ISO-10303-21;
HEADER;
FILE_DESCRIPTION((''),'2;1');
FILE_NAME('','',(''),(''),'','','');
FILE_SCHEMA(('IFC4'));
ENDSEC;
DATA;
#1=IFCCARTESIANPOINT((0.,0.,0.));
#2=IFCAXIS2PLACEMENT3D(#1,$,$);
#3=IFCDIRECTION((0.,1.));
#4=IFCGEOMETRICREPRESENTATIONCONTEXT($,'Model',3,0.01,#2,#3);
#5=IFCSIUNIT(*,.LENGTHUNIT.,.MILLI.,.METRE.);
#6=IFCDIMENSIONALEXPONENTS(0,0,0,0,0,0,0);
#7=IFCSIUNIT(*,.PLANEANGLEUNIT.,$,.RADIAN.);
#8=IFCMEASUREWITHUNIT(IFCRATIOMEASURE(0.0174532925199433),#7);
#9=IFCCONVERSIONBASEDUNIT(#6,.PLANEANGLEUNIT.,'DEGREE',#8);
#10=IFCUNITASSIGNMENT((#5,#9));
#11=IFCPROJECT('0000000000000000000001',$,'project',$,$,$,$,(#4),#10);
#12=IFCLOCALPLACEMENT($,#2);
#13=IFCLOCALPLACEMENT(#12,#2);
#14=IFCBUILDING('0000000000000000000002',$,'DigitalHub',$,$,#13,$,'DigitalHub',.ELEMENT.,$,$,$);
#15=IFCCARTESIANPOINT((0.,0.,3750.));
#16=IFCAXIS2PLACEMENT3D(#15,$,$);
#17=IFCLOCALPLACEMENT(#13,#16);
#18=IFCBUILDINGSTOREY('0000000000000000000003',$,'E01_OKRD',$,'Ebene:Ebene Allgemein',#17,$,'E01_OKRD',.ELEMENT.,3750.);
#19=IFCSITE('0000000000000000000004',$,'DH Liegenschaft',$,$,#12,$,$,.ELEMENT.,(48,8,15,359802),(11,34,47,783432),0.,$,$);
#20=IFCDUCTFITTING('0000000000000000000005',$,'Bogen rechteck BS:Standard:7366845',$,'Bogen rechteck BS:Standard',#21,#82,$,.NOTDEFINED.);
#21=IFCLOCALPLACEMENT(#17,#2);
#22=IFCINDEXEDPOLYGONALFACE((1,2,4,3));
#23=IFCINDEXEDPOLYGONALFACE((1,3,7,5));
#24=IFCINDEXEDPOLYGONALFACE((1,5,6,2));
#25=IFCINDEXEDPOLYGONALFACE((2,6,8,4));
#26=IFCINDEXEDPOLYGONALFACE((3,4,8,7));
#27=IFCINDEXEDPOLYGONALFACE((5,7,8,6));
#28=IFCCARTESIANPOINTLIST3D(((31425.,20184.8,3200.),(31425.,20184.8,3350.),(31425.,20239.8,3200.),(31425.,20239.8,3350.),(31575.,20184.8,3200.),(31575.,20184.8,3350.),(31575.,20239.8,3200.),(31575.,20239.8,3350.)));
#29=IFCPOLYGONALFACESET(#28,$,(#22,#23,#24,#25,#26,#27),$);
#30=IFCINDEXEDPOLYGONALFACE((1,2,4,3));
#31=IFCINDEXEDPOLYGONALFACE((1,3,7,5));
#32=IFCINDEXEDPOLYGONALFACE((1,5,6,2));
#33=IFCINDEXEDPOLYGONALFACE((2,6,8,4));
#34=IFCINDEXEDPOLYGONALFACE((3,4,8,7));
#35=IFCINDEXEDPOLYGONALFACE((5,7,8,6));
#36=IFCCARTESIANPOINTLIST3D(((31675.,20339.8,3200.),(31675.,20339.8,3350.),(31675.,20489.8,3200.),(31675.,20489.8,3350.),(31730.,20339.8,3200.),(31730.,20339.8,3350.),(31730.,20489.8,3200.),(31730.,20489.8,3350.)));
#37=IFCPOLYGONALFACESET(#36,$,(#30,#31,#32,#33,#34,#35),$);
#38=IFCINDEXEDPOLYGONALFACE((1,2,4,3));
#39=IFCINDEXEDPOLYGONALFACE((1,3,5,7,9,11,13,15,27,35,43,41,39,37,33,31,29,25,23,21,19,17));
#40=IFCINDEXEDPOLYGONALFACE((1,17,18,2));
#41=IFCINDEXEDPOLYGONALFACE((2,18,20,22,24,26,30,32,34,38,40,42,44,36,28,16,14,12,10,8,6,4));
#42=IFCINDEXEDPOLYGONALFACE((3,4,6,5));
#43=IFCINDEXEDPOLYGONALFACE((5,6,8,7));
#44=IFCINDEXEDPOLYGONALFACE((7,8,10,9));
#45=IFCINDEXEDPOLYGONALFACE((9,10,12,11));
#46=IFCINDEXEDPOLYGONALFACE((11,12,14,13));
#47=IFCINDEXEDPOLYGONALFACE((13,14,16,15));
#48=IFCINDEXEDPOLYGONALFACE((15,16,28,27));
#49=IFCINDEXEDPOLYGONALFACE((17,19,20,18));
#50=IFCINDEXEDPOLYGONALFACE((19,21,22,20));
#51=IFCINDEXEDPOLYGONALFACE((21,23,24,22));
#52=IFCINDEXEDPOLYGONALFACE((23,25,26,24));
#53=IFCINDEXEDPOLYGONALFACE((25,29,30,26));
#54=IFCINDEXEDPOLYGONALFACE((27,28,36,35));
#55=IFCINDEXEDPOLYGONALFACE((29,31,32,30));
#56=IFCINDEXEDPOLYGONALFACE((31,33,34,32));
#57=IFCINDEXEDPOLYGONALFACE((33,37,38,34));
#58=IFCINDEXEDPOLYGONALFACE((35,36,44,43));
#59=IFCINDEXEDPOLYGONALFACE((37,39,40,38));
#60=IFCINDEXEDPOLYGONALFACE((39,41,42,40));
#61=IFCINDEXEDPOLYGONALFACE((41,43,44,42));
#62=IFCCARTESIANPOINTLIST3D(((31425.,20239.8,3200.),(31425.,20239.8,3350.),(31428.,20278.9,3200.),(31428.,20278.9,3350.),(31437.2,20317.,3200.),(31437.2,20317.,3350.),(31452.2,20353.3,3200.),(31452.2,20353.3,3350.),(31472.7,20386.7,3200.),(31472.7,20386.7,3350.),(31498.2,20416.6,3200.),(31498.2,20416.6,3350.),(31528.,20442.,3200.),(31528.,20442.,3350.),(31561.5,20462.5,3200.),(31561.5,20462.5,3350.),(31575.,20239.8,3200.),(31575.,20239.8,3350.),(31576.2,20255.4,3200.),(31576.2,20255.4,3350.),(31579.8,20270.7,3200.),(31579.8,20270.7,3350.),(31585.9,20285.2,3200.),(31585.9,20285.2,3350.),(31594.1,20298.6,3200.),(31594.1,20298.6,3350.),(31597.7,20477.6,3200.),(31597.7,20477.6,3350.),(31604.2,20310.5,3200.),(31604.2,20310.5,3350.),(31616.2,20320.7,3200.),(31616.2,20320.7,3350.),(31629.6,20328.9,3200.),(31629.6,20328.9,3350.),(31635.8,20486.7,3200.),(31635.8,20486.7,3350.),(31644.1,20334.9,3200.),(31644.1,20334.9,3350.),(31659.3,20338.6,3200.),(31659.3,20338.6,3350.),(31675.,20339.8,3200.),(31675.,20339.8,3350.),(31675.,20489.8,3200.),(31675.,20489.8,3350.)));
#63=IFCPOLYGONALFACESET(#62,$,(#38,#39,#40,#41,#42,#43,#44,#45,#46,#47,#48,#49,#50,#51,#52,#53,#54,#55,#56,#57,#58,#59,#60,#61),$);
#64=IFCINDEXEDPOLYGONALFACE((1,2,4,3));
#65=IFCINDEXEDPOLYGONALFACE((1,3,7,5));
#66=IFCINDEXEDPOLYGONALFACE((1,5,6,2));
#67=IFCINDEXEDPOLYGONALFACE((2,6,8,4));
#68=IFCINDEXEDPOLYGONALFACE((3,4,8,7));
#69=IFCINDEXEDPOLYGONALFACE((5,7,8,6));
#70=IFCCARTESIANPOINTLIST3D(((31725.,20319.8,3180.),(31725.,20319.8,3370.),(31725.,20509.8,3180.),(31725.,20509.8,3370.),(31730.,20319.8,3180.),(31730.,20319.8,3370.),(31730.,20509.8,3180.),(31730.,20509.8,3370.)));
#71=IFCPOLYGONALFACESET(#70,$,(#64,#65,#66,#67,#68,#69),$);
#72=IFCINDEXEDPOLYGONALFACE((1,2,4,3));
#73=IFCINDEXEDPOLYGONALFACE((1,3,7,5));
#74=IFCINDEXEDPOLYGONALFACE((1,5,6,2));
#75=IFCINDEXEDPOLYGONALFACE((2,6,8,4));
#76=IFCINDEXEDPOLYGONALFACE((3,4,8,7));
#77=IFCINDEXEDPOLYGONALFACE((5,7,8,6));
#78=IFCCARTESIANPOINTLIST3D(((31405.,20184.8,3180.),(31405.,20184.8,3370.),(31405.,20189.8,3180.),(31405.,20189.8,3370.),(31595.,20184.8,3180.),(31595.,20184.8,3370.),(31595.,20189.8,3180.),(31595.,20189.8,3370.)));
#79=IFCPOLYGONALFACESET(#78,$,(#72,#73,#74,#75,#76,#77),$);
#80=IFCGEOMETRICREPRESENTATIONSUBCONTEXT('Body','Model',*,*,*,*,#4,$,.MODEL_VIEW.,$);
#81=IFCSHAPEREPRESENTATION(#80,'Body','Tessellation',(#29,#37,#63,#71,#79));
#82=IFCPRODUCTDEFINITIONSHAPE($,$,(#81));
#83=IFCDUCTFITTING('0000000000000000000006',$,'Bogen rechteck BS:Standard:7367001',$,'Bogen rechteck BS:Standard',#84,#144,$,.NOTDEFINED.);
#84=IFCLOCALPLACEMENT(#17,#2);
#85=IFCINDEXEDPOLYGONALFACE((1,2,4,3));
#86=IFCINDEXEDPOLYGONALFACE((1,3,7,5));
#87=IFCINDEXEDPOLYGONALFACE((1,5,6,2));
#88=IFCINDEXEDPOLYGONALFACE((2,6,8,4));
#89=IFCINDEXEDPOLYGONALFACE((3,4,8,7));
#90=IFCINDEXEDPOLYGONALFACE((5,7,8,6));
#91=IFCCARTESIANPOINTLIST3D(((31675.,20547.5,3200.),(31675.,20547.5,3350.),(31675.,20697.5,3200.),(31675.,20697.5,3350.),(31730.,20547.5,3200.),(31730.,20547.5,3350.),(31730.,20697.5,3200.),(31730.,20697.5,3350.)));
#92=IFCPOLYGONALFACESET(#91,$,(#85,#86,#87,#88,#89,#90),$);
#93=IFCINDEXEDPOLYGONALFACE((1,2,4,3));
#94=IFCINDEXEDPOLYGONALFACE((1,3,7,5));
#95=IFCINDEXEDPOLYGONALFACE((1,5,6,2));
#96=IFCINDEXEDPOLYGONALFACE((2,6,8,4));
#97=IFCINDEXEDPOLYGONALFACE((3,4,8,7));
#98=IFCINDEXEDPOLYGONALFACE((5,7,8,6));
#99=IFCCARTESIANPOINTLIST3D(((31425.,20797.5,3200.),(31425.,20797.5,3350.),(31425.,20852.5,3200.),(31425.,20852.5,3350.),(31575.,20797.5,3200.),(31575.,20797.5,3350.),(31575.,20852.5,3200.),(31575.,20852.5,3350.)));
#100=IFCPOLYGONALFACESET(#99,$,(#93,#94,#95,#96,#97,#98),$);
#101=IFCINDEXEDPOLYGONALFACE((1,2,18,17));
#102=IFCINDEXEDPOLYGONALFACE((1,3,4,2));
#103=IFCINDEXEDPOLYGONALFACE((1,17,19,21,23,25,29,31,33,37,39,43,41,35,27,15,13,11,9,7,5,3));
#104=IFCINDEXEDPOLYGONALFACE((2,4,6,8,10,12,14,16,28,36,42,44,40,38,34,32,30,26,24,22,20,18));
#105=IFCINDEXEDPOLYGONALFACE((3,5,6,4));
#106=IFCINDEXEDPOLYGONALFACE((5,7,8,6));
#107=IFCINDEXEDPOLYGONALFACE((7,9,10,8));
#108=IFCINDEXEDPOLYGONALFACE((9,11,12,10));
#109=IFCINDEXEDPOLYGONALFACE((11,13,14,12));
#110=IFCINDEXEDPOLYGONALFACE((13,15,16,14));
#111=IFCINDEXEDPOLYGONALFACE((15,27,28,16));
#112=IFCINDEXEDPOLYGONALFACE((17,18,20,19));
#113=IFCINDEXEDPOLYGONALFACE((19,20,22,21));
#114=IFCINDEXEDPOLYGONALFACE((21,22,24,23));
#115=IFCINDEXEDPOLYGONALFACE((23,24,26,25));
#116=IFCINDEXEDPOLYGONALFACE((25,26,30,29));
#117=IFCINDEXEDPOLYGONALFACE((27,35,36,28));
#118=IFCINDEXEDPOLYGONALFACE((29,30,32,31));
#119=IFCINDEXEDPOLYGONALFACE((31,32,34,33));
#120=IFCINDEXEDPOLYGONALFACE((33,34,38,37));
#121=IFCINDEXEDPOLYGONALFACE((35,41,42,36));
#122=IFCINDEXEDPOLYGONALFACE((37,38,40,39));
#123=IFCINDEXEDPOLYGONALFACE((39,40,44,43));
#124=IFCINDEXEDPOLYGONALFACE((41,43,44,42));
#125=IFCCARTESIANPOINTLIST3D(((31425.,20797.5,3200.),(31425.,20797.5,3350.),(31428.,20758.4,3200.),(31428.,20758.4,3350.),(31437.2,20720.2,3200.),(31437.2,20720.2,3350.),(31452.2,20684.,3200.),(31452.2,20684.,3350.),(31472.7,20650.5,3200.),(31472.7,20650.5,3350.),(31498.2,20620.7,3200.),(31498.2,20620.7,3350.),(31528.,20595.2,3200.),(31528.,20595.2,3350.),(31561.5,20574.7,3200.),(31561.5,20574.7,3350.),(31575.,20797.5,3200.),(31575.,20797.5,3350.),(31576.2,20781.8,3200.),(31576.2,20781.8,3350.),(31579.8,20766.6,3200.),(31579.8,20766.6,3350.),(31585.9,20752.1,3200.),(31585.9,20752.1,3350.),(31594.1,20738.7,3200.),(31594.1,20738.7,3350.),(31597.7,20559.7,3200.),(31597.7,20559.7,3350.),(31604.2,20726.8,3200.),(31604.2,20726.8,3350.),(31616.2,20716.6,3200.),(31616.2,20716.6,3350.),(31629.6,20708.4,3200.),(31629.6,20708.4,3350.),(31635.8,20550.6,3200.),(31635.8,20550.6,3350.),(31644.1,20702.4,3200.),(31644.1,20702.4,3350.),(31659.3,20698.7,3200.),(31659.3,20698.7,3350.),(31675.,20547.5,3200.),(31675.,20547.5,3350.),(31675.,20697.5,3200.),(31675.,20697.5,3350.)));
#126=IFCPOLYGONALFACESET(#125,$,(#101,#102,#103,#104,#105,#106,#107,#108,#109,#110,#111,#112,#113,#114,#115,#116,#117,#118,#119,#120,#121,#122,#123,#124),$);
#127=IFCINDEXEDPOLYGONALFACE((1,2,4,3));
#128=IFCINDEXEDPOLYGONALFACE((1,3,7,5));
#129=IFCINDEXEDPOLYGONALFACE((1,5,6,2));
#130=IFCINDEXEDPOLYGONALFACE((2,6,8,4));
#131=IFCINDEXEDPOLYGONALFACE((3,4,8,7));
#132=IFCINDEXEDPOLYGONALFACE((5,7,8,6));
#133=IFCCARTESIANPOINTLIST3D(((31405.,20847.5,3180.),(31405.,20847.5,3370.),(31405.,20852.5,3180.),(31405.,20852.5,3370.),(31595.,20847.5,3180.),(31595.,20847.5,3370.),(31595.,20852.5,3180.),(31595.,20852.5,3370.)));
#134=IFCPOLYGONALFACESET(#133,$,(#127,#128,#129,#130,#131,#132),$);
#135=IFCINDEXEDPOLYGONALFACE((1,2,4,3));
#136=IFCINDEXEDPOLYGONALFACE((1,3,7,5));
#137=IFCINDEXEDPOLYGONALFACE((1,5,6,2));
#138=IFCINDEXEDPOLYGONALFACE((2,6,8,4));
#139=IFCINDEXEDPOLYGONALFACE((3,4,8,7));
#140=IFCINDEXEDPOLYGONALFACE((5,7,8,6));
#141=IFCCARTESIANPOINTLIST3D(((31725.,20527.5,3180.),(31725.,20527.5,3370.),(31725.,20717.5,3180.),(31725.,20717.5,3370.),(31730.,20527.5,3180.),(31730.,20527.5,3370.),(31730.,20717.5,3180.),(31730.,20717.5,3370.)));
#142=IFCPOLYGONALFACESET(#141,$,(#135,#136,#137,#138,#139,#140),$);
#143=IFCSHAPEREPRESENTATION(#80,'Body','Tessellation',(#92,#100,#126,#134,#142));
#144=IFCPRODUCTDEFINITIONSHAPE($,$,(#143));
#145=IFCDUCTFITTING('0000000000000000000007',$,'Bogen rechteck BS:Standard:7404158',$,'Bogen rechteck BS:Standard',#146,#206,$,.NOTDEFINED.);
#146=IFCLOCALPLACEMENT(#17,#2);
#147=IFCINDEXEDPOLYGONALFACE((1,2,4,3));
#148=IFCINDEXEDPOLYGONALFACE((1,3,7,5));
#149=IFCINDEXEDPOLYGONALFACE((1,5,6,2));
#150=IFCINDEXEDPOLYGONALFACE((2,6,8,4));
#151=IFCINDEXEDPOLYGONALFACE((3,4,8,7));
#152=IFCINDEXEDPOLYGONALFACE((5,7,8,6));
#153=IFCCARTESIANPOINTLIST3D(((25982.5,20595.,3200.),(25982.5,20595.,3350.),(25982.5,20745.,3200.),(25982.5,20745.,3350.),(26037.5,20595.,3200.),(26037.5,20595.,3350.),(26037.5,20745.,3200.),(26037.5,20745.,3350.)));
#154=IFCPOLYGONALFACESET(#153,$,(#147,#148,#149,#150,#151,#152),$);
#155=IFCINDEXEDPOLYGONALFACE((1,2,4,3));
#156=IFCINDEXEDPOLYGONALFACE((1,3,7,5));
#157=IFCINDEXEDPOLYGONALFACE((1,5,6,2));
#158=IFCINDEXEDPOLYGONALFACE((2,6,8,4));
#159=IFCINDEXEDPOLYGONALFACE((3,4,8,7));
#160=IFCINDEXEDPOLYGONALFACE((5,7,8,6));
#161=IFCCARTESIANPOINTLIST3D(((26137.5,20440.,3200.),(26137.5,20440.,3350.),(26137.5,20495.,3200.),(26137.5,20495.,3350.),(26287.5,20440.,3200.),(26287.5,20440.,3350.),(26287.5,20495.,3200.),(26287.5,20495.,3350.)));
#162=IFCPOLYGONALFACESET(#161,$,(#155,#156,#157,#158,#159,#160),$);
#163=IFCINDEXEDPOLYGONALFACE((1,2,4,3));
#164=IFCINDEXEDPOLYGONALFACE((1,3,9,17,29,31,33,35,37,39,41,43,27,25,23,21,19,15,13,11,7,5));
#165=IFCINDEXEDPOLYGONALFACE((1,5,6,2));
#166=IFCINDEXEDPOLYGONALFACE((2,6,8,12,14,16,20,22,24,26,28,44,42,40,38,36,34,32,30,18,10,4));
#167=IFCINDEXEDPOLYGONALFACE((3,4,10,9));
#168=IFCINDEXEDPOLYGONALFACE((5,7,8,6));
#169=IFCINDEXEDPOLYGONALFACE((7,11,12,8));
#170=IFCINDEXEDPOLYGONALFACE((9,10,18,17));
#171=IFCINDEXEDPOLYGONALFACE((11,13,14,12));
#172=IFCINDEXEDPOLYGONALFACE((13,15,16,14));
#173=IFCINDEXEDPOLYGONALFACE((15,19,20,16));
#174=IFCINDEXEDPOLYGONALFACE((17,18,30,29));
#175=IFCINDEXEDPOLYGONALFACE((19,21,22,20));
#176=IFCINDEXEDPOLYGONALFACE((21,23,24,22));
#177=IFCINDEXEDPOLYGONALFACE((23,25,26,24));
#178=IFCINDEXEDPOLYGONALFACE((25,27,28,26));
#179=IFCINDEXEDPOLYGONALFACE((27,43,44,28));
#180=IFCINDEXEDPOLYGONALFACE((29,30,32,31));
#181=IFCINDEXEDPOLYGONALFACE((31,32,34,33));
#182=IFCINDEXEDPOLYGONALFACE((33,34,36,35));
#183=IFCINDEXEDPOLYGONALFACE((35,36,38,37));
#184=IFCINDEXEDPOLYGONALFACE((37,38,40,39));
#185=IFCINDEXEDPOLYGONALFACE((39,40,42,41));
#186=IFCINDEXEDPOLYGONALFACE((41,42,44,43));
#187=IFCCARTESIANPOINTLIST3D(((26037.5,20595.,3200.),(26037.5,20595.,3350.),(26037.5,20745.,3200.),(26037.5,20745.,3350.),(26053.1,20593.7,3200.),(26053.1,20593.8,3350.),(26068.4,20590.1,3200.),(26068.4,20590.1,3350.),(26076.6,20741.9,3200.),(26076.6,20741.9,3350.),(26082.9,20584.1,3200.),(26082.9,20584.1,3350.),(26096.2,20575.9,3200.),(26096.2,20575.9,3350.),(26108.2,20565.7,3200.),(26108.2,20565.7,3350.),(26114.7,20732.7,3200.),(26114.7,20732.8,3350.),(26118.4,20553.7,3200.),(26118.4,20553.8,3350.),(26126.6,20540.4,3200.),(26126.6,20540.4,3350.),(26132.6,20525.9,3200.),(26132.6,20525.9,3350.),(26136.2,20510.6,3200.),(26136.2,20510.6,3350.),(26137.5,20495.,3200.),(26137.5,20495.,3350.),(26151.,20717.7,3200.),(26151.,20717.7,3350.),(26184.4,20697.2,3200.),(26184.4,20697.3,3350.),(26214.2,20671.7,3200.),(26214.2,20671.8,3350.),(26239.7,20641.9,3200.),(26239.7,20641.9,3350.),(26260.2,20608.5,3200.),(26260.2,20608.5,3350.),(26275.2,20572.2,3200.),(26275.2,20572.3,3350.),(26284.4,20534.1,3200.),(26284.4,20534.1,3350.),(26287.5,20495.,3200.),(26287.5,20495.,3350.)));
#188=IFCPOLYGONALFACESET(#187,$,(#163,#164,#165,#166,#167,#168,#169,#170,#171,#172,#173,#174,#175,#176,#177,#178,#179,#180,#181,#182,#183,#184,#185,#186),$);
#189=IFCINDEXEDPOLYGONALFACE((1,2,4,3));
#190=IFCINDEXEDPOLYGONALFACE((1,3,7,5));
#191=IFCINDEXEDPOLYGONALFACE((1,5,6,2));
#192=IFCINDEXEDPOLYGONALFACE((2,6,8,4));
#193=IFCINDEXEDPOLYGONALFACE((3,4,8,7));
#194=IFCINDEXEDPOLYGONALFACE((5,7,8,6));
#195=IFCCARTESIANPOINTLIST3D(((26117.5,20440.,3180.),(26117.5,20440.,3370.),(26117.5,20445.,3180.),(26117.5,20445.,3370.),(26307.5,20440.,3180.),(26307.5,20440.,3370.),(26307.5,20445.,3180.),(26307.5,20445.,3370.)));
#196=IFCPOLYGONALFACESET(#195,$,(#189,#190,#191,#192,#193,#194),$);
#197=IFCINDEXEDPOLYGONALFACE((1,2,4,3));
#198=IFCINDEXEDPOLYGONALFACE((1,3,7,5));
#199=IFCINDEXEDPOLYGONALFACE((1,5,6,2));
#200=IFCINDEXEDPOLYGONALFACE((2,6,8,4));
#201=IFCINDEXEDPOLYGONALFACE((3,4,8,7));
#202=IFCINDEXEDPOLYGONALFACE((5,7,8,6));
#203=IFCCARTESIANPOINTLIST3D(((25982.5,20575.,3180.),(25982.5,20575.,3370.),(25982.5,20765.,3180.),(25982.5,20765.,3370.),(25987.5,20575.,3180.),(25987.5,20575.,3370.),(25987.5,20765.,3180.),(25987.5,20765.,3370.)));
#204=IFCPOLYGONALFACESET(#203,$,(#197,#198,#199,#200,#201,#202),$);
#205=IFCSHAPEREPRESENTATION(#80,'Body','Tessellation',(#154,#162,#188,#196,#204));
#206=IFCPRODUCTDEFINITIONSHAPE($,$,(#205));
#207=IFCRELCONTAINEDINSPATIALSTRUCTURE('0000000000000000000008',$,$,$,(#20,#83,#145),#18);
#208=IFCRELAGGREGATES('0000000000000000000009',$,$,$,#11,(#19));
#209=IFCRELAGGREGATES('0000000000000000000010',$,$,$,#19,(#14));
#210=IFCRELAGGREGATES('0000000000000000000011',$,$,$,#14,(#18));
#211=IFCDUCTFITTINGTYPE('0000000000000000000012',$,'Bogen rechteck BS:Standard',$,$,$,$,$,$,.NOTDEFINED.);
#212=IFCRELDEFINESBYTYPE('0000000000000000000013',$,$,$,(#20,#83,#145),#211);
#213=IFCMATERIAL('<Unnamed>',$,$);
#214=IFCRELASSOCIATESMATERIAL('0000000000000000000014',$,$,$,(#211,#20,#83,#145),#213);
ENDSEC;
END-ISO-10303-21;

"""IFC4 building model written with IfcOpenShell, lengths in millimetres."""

from ifc_helpers import new_model, entity, si_unit, converted_unit, direction, frame, origin, place, context, subcontext, project, spatial, indexed_curve, outline, extrude, source, transform, mapped, material, type_object, type_shapes, element, save


model = new_model("IFC4")

# Units and contexts
model_context = context("Model", 3, precision=0.01, world=origin(), true_north=direction((0.0, 1.0)))
body_context = subcontext(model_context, "Body", "Model", "MODEL_VIEW")
ifc_project = project(units=[si_unit("LENGTHUNIT", "METRE", prefix="MILLI"), converted_unit("PLANEANGLEUNIT", "DEGREE", entity("IfcRatioMeasure", 0.0174532925199433), si_unit("PLANEANGLEUNIT", "RADIAN"), dimensions=[0, 0, 0, 0, 0, 0, 0])], contexts=[model_context])

# Site, building, storey
site_placement = place(None, origin())
site = spatial("IfcSite", under=ifc_project, at=site_placement, Name="DH Liegenschaft", CompositionType="ELEMENT", RefLatitude=(48, 8, 15, 359802), RefLongitude=(11, 34, 47, 783432), RefElevation=0.0)
building_placement = place(site_placement, origin())
building = spatial("IfcBuilding", under=site, at=building_placement, Name="DigitalHub", LongName="DigitalHub", CompositionType="ELEMENT")
storey_placement = place(building_placement, frame((0.0, 0.0, 3750.0)))
storey = spatial("IfcBuildingStorey", under=building, at=storey_placement, Name="E01_OKRD", ObjectType="Ebene:Ebene Allgemein", LongName="E01_OKRD", CompositionType="ELEMENT", Elevation=3750.0)

# Shared definitions
ifc_material_1 = material(Name="<Unnamed>")

# Duct fittings
duct_fitting_type_1 = type_object("IfcDuctFittingType", Name="Bogen rechteck BS:Standard", PredefinedType="NOTDEFINED", material=ifc_material_1)
shared_shape_1 = source(origin(), body_context, "Body", "SweptSolid", [
    extrude(outline(indexed_curve([(-27.5, -75.0), (27.5, -75.0), (27.5, 75.0), (-27.5, 75.0), (-27.5, -75.0)], self_intersect=False)), frame((0.0, 202.5, -75.0), z_axis=(0.0, 0.0, 1.0), x_axis=(0.0, 1.0, 0.0)), (0.0, 0.0, 1.0), 150.0),
    extrude(outline(indexed_curve([(-75.0, -27.5), (75.0, -27.5), (75.0, 27.5), (-75.0, 27.5), (-75.0, -27.5)], self_intersect=False)), frame((-202.5, 0.0, -75.0), z_axis=(0.0, 0.0, 1.0), x_axis=(0.0, -1.0, 0.0)), (0.0, 0.0, 1.0), 150.0),
    extrude(outline(indexed_curve([(-162.5, -87.5), (-12.5, -87.5), (-11.3, -71.9), (-7.6, -56.6), (-1.6, -42.1), (6.6, -28.7), (16.8, -16.8), (28.7, -6.6), (42.1, 1.6), (56.6, 7.6), (71.9, 11.3), (87.5, 12.5), (87.5, 162.5), (48.4, 159.4), (10.2, 150.3), (-26.0, 135.3), (-59.4, 114.8), (-89.3, 89.3), (-114.8, 59.4), (-135.3, 26.0), (-150.3, -10.2), (-159.4, -48.4), (-162.5, -87.5)], self_intersect=False)), frame((-87.5, 87.5, -75.0), z_axis=(0.0, 0.0, 1.0), x_axis=(-1.0, 0.0, 0.0)), (0.0, 0.0, 1.0), 150.0),
    extrude(outline(indexed_curve([(-2.5, -95.0), (2.5, -95.0), (2.5, 95.0), (-2.5, 95.0), (-2.5, -95.0)], self_intersect=False)), frame((-227.5, 0.0, -95.0)), (0.0, 0.0, 1.0), 190.0),
    extrude(outline(indexed_curve([(-2.5, -95.0), (2.5, -95.0), (2.5, 95.0), (-2.5, 95.0), (-2.5, -95.0)], self_intersect=False)), frame((0.0, 227.5, -95.0), z_axis=(0.0, 0.0, 1.0), x_axis=(0.0, 1.0, 0.0)), (0.0, 0.0, 1.0), 190.0),
])
type_shapes(duct_fitting_type_1, [shared_shape_1])
for number, where, z_axis, x_axis, name in (
    (1, (31500.0, 20414.8, 3275.0), (0.0, 0.0, 1.0), (-1.0, 0.0, 0.0), "Bogen rechteck BS:Standard:7366845"),
    (2, (31500.0, 20622.5, 3275.0), (0.0, 0.0, 1.0), (0.0, -1.0, 0.0), "Bogen rechteck BS:Standard:7367001"),
    (3, (26212.5, 20670.0, 3275.0), (0.0, 0.0002, 1.0), (0.0, 1.0, -0.0002), "Bogen rechteck BS:Standard:7404158"),
):
    element("IfcDuctFitting", number, at=place(storey_placement, frame(where, z_axis=z_axis, x_axis=x_axis)), inside=storey, type_object=duct_fitting_type_1, material=ifc_material_1, Name=name, ObjectType="Bogen rechteck BS:Standard", PredefinedType="NOTDEFINED", context=body_context, shape_type="MappedRepresentation", body=[
        mapped(shared_shape_1, transform((0.0, 0.0, 0.0), scale=1.0)),
    ])

save(model, "model.ifc")
